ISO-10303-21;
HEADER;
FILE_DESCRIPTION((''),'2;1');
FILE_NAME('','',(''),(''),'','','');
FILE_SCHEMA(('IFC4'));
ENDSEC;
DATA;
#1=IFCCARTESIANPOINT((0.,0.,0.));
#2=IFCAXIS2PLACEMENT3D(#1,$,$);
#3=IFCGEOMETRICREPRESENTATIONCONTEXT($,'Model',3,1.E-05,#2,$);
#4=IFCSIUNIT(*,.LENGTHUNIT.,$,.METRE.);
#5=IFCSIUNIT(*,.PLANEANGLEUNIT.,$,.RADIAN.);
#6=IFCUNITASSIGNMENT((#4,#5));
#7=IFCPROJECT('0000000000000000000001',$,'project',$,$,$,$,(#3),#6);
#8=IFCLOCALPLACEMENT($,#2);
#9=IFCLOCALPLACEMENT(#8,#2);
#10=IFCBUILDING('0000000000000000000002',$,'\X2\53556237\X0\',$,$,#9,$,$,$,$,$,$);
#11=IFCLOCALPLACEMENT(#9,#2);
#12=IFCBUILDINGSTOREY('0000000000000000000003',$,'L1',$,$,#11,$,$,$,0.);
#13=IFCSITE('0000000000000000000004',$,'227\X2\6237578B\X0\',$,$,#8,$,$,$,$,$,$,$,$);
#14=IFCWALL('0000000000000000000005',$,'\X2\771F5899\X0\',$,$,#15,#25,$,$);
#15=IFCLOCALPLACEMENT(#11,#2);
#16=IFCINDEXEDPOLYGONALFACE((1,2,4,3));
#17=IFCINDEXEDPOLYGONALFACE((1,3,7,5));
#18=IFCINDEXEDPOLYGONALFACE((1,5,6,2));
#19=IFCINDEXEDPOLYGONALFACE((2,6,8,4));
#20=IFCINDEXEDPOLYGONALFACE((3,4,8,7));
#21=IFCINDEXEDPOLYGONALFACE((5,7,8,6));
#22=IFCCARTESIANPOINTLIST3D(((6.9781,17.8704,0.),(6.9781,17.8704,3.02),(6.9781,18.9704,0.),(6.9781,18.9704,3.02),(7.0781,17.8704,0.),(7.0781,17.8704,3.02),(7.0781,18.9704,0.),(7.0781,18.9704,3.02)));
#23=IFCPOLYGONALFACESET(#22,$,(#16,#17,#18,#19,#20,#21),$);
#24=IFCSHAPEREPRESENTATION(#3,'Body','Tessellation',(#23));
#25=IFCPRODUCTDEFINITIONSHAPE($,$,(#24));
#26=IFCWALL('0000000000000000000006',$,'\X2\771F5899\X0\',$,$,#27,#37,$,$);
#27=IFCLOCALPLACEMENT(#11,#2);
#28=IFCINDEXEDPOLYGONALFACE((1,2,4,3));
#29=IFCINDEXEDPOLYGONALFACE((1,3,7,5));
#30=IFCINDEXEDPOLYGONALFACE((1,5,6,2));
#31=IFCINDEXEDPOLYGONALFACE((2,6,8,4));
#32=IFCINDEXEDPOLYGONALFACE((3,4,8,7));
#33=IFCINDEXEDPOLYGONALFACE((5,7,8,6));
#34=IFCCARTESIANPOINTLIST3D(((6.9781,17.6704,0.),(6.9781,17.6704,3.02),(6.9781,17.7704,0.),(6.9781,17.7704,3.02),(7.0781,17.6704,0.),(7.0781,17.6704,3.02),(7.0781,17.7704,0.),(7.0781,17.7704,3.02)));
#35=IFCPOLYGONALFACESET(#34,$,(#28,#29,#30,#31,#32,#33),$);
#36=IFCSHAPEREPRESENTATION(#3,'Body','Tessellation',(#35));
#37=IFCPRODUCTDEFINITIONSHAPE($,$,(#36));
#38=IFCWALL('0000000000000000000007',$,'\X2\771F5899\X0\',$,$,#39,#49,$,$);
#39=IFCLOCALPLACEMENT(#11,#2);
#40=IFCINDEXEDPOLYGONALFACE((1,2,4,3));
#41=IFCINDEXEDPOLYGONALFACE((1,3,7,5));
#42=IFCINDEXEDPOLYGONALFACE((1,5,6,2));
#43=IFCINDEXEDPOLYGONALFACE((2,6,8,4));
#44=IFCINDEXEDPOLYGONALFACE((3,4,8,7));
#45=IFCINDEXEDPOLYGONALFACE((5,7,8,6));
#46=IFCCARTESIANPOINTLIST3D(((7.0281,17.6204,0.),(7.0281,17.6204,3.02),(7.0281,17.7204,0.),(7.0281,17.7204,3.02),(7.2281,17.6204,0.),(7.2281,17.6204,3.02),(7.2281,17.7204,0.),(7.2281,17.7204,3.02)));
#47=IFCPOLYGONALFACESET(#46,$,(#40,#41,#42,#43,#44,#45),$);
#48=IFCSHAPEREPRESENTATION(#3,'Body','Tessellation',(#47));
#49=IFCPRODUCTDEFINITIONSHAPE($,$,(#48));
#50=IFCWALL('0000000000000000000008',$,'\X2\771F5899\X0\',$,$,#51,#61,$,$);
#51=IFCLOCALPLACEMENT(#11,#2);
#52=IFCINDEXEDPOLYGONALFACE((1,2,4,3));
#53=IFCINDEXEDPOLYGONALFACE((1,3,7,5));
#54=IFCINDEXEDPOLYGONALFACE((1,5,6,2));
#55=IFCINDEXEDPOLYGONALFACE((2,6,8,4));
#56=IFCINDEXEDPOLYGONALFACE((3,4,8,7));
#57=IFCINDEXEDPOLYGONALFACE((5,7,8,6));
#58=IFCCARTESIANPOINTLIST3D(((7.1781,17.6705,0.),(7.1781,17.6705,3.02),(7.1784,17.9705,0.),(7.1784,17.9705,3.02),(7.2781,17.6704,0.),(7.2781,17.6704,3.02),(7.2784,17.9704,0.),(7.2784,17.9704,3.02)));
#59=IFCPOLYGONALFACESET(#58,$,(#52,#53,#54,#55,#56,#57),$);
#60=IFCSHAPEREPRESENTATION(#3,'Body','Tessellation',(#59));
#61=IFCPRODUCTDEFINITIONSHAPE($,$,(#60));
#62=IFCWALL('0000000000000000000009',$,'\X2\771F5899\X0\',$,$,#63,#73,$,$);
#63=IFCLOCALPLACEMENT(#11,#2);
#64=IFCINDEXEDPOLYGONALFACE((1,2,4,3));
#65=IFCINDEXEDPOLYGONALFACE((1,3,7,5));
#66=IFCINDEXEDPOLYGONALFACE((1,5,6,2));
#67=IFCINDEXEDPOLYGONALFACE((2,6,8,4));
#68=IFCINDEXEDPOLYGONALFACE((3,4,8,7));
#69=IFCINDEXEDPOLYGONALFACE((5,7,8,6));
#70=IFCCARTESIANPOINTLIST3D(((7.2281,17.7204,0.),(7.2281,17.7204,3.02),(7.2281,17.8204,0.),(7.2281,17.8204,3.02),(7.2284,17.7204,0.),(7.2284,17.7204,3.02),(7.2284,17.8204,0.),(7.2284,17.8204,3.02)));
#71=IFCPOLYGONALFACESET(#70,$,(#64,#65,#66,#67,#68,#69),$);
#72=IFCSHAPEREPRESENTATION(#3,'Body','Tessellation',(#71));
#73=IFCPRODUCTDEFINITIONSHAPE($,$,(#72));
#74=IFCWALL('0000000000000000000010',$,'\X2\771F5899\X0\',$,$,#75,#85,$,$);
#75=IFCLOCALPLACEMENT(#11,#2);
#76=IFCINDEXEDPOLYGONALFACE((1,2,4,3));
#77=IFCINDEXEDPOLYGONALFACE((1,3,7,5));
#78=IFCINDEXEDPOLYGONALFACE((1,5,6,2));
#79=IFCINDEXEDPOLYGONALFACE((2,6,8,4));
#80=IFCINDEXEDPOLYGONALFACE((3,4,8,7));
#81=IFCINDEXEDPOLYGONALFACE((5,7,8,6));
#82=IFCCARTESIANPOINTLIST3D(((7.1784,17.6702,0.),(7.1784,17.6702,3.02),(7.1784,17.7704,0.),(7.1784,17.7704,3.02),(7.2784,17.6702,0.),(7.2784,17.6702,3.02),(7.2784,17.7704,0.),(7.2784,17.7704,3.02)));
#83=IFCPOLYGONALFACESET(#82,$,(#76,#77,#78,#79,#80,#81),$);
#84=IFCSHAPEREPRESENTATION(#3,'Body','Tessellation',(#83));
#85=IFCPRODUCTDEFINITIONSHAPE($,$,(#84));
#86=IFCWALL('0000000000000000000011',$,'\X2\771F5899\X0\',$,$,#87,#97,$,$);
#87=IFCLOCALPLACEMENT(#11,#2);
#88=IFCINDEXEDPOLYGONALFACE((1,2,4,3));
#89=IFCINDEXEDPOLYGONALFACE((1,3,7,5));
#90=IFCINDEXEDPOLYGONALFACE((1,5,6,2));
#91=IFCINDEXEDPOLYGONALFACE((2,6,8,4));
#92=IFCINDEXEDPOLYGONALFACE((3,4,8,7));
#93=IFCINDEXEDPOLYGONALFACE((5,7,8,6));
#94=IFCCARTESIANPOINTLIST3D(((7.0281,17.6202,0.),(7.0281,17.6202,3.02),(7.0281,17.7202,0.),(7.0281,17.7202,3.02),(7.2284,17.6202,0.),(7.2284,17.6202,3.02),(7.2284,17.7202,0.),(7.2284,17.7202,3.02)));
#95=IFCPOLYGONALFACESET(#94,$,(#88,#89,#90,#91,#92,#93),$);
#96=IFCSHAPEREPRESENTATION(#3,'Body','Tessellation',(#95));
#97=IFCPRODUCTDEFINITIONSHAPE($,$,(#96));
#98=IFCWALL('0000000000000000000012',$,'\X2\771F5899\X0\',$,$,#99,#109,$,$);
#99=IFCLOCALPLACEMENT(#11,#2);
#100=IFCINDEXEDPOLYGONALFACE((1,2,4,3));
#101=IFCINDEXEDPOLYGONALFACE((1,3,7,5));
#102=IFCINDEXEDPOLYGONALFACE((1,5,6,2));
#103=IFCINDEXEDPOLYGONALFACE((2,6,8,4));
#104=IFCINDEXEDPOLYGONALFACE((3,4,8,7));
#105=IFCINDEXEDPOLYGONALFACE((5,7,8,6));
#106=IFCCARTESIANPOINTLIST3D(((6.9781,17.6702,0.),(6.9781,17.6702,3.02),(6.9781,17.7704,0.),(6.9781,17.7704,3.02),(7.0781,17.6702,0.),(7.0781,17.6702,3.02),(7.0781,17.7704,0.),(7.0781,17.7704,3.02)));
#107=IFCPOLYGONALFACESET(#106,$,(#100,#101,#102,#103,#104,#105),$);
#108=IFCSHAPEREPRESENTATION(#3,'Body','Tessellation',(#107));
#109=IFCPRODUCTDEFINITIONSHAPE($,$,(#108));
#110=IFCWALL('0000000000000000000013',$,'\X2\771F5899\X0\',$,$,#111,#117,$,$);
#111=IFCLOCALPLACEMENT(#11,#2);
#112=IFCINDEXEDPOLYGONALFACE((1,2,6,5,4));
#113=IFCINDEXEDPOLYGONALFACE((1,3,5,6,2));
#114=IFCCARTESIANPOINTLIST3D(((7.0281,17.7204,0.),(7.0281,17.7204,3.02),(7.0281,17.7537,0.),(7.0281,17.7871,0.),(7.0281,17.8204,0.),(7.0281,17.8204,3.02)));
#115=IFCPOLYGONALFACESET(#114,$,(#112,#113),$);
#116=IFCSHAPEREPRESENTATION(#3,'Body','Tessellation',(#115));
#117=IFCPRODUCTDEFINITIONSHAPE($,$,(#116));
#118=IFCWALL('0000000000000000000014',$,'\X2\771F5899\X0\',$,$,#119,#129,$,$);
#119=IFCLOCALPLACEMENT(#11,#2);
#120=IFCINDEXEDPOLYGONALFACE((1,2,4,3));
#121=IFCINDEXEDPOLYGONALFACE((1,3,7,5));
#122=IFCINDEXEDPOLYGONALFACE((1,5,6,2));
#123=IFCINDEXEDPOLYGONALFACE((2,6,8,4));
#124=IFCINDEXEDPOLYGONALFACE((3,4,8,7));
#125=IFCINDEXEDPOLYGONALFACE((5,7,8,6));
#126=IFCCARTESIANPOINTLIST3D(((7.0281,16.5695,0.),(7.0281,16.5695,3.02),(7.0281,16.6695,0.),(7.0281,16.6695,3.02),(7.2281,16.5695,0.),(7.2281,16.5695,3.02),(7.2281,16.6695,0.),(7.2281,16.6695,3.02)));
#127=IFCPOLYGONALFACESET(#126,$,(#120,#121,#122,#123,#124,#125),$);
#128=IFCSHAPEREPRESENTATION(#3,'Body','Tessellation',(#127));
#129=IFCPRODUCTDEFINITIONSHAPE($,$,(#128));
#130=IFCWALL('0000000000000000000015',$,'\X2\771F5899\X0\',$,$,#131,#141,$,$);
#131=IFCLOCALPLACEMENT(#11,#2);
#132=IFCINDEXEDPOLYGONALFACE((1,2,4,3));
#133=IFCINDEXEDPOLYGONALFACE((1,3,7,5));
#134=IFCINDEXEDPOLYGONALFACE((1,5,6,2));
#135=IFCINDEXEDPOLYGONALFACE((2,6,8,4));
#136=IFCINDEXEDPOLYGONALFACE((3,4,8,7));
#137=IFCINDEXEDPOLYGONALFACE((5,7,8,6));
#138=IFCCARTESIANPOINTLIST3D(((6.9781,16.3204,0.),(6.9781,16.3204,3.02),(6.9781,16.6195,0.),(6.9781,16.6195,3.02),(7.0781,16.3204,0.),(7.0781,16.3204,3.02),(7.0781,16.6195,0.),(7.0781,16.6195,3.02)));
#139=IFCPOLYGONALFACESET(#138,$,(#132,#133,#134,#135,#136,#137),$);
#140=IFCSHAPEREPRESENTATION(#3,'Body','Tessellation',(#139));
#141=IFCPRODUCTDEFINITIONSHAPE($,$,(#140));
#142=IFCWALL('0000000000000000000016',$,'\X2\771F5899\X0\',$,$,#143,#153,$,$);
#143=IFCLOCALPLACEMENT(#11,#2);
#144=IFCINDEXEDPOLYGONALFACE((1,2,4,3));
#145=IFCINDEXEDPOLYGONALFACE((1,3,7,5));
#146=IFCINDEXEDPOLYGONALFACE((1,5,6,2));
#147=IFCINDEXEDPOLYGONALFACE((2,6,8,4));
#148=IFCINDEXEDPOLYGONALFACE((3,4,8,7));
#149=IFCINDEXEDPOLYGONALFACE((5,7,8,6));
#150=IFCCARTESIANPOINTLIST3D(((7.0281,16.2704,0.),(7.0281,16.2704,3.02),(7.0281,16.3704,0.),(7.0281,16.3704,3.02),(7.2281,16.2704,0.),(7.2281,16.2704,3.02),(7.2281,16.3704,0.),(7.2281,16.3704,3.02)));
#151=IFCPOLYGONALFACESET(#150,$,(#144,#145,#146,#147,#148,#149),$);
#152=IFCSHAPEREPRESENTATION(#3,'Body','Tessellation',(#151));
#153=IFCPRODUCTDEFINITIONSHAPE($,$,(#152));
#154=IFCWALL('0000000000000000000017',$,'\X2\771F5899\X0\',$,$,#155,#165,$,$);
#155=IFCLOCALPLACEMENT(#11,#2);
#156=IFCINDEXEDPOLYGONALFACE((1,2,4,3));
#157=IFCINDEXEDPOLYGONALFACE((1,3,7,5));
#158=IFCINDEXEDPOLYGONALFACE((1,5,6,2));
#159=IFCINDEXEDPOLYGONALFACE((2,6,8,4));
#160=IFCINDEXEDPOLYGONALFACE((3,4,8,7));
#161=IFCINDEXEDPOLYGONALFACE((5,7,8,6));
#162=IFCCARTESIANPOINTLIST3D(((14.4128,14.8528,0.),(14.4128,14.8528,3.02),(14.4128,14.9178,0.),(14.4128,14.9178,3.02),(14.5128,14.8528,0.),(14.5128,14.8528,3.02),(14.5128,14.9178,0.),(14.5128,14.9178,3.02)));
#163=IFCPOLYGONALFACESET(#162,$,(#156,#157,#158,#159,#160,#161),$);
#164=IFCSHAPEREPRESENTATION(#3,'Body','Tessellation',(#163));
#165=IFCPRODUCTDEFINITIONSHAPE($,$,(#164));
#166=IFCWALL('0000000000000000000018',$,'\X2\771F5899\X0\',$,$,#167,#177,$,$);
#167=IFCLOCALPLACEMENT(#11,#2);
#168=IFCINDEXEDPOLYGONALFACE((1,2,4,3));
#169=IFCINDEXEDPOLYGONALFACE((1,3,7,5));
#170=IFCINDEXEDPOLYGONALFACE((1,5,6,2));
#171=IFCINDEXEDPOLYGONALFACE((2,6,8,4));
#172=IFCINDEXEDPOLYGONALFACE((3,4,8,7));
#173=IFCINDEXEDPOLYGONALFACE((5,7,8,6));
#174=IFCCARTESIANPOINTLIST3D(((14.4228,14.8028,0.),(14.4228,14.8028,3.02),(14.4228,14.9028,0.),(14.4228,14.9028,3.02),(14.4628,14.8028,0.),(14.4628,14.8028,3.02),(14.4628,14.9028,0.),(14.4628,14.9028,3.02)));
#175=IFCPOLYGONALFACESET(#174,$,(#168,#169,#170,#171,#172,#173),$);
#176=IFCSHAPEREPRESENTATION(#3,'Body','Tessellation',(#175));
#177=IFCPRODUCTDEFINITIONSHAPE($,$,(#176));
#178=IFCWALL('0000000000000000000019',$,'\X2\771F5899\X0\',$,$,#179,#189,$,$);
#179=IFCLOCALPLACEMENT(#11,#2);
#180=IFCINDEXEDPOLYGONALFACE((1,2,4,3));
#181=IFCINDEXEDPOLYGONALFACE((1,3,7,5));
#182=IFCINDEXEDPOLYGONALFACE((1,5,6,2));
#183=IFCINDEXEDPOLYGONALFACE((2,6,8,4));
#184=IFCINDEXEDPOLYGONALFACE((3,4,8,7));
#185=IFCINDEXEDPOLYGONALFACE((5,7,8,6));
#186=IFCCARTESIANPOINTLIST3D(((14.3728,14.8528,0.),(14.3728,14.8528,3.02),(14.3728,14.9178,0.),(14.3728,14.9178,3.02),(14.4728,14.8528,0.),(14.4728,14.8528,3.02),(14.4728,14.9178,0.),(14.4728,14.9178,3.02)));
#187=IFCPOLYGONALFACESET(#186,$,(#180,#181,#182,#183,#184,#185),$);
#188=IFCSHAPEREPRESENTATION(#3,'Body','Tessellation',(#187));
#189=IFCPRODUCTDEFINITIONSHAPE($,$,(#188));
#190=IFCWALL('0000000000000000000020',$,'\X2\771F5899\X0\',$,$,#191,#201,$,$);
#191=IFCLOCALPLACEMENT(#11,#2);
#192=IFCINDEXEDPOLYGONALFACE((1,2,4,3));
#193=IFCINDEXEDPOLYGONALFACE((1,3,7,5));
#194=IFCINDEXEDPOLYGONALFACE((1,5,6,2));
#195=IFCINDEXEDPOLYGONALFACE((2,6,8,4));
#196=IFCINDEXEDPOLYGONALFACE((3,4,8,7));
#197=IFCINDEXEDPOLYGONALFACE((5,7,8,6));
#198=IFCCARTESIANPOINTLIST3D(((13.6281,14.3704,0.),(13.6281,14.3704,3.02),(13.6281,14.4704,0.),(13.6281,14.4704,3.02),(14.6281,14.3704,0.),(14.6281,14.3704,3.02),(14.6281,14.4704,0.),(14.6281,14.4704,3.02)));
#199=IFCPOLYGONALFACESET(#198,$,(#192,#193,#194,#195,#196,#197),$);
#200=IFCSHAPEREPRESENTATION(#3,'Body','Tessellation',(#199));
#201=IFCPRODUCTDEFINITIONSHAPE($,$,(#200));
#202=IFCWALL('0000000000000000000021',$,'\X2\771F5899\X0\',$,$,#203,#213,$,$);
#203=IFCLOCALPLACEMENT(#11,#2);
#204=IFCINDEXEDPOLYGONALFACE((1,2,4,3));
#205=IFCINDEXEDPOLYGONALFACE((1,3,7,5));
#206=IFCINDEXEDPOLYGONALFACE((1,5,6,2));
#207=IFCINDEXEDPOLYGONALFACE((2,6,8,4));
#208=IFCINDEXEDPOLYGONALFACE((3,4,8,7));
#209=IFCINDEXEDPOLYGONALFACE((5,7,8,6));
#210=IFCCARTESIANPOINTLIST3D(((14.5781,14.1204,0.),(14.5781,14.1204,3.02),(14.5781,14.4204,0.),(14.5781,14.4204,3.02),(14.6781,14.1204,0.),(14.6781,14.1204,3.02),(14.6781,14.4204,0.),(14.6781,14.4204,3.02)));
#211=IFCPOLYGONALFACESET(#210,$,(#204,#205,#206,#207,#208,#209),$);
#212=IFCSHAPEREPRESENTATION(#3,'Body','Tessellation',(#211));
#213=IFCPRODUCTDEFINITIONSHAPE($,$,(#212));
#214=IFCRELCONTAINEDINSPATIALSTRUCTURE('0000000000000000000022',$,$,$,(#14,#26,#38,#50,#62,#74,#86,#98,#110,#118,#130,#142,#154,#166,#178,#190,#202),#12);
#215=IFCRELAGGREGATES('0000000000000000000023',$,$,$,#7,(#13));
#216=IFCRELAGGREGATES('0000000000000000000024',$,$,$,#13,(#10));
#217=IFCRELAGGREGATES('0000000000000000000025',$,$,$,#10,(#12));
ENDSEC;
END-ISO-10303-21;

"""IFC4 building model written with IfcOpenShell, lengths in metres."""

from ifc_helpers import new_model, si_unit, origin, place, context, project, spatial, polyline, outline, extrude, element, save


model = new_model("IFC4")

# Units and contexts
model_context = context("Model", 3, precision=1e-05, world=origin())
ifc_project = project(units=[si_unit("LENGTHUNIT", "METRE"), si_unit("PLANEANGLEUNIT", "RADIAN")], contexts=[model_context])

# Site, building, storey
site_placement = place(None, origin())
site = spatial("IfcSite", under=ifc_project, at=site_placement, Name="227户型")
building_placement = place(site_placement, origin())
building = spatial("IfcBuilding", under=site, at=building_placement, Name="单户")
storey_placement = place(building_placement, origin())
storey = spatial("IfcBuildingStorey", under=building, at=storey_placement, Name="L1", Elevation=0.0)

# Walls
wall_1_placement = place(storey_placement, origin())
element("IfcWall", 1, at=wall_1_placement, inside=storey, Name="真墙", context=model_context, shape_type="SweptSolid", body=[
    extrude(outline(polyline([(7.0781, 18.9704), (7.0781, 17.8704), (6.9781, 17.8704), (6.9781, 18.9704), (7.0781, 18.9704)])), origin(), (0.0, 0.0, 1.0), 3.02),
])
wall_2_placement = place(storey_placement, origin())
element("IfcWall", 2, at=wall_2_placement, inside=storey, Name="真墙", context=model_context, shape_type="SweptSolid", body=[
    extrude(outline(polyline([(7.0781, 17.7704), (7.0781, 17.6704), (6.9781, 17.6704), (6.9781, 17.7704), (7.0781, 17.7704)])), origin(), (0.0, 0.0, 1.0), 3.02),
])
wall_3_placement = place(storey_placement, origin())
element("IfcWall", 3, at=wall_3_placement, inside=storey, Name="真墙", context=model_context, shape_type="SweptSolid", body=[
    extrude(outline(polyline([(7.0281, 17.7204), (7.2281, 17.7204), (7.2281, 17.6204), (7.0281, 17.6204), (7.0281, 17.7204)])), origin(), (0.0, 0.0, 1.0), 3.02),
])
wall_4_placement = place(storey_placement, origin())
element("IfcWall", 4, at=wall_4_placement, inside=storey, Name="真墙", context=model_context, shape_type="SweptSolid", body=[
    extrude(outline(polyline([(7.1781, 17.6705), (7.1784, 17.9705), (7.2784, 17.9704), (7.2781, 17.6704), (7.1781, 17.6705)])), origin(), (0.0, 0.0, 1.0), 3.02),
])
wall_5_placement = place(storey_placement, origin())
element("IfcWall", 5, at=wall_5_placement, inside=storey, Name="真墙", context=model_context, shape_type="SweptSolid", body=[
    extrude(outline(polyline([(7.2281, 17.8204), (7.2284, 17.8204), (7.2284, 17.7204), (7.2281, 17.7204), (7.2281, 17.8204)])), origin(), (0.0, 0.0, 1.0), 3.02),
])
wall_6_placement = place(storey_placement, origin())
element("IfcWall", 6, at=wall_6_placement, inside=storey, Name="真墙", context=model_context, shape_type="SweptSolid", body=[
    extrude(outline(polyline([(7.2784, 17.7704), (7.2784, 17.6702), (7.1784, 17.6702), (7.1784, 17.7704), (7.2784, 17.7704)])), origin(), (0.0, 0.0, 1.0), 3.02),
])
wall_7_placement = place(storey_placement, origin())
element("IfcWall", 7, at=wall_7_placement, inside=storey, Name="真墙", context=model_context, shape_type="SweptSolid", body=[
    extrude(outline(polyline([(7.2284, 17.6202), (7.0281, 17.6202), (7.0281, 17.7202), (7.2284, 17.7202), (7.2284, 17.6202)])), origin(), (0.0, 0.0, 1.0), 3.02),
])
wall_8_placement = place(storey_placement, origin())
element("IfcWall", 8, at=wall_8_placement, inside=storey, Name="真墙", context=model_context, shape_type="SweptSolid", body=[
    extrude(outline(polyline([(6.9781, 17.6702), (6.9781, 17.7704), (7.0781, 17.7704), (7.0781, 17.6702), (6.9781, 17.6702)])), origin(), (0.0, 0.0, 1.0), 3.02),
])
wall_9_placement = place(storey_placement, origin())
element("IfcWall", 9, at=wall_9_placement, inside=storey, Name="真墙", context=model_context, shape_type="SweptSolid", body=[
    extrude(outline(polyline([(7.0281, 17.8204), (7.0281, 17.8204), (7.0281, 17.7204), (7.0281, 17.7204), (7.0281, 17.8204)])), origin(), (0.0, 0.0, 1.0), 3.02),
])
wall_10_placement = place(storey_placement, origin())
element("IfcWall", 10, at=wall_10_placement, inside=storey, Name="真墙", context=model_context, shape_type="SweptSolid", body=[
    extrude(outline(polyline([(7.2281, 16.5695), (7.0281, 16.5695), (7.0281, 16.6695), (7.2281, 16.6695), (7.2281, 16.5695)])), origin(), (0.0, 0.0, 1.0), 3.02),
])
wall_11_placement = place(storey_placement, origin())
element("IfcWall", 11, at=wall_11_placement, inside=storey, Name="真墙", context=model_context, shape_type="SweptSolid", body=[
    extrude(outline(polyline([(7.0781, 16.6195), (7.0781, 16.3204), (6.9781, 16.3204), (6.9781, 16.6195), (7.0781, 16.6195)])), origin(), (0.0, 0.0, 1.0), 3.02),
])
wall_12_placement = place(storey_placement, origin())
element("IfcWall", 12, at=wall_12_placement, inside=storey, Name="真墙", context=model_context, shape_type="SweptSolid", body=[
    extrude(outline(polyline([(7.0281, 16.3704), (7.2281, 16.3704), (7.2281, 16.2704), (7.0281, 16.2704), (7.0281, 16.3704)])), origin(), (0.0, 0.0, 1.0), 3.02),
])
wall_13_placement = place(storey_placement, origin())
element("IfcWall", 13, at=wall_13_placement, inside=storey, Name="真墙", context=model_context, shape_type="SweptSolid", body=[
    extrude(outline(polyline([(14.5128, 14.9178), (14.5128, 14.8528), (14.4128, 14.8528), (14.4128, 14.9178), (14.5128, 14.9178)])), origin(), (0.0, 0.0, 1.0), 3.02),
])
wall_14_placement = place(storey_placement, origin())
element("IfcWall", 14, at=wall_14_placement, inside=storey, Name="真墙", context=model_context, shape_type="SweptSolid", body=[
    extrude(outline(polyline([(14.4628, 14.8028), (14.4228, 14.8028), (14.4228, 14.9028), (14.4628, 14.9028), (14.4628, 14.8028)])), origin(), (0.0, 0.0, 1.0), 3.02),
])
wall_15_placement = place(storey_placement, origin())
element("IfcWall", 15, at=wall_15_placement, inside=storey, Name="真墙", context=model_context, shape_type="SweptSolid", body=[
    extrude(outline(polyline([(14.3728, 14.8528), (14.3728, 14.9178), (14.4728, 14.9178), (14.4728, 14.8528), (14.3728, 14.8528)])), origin(), (0.0, 0.0, 1.0), 3.02),
])
wall_16_placement = place(storey_placement, origin())
element("IfcWall", 16, at=wall_16_placement, inside=storey, Name="真墙", context=model_context, shape_type="SweptSolid", body=[
    extrude(outline(polyline([(13.6281, 14.4704), (14.6281, 14.4704), (14.6281, 14.3704), (13.6281, 14.3704), (13.6281, 14.4704)])), origin(), (0.0, 0.0, 1.0), 3.02),
])
wall_17_placement = place(storey_placement, origin())
element("IfcWall", 17, at=wall_17_placement, inside=storey, Name="真墙", context=model_context, shape_type="SweptSolid", body=[
    extrude(outline(polyline([(14.6781, 14.4204), (14.6781, 14.1204), (14.5781, 14.1204), (14.5781, 14.4204), (14.6781, 14.4204)])), origin(), (0.0, 0.0, 1.0), 3.02),
])

save(model, "model.ifc")
